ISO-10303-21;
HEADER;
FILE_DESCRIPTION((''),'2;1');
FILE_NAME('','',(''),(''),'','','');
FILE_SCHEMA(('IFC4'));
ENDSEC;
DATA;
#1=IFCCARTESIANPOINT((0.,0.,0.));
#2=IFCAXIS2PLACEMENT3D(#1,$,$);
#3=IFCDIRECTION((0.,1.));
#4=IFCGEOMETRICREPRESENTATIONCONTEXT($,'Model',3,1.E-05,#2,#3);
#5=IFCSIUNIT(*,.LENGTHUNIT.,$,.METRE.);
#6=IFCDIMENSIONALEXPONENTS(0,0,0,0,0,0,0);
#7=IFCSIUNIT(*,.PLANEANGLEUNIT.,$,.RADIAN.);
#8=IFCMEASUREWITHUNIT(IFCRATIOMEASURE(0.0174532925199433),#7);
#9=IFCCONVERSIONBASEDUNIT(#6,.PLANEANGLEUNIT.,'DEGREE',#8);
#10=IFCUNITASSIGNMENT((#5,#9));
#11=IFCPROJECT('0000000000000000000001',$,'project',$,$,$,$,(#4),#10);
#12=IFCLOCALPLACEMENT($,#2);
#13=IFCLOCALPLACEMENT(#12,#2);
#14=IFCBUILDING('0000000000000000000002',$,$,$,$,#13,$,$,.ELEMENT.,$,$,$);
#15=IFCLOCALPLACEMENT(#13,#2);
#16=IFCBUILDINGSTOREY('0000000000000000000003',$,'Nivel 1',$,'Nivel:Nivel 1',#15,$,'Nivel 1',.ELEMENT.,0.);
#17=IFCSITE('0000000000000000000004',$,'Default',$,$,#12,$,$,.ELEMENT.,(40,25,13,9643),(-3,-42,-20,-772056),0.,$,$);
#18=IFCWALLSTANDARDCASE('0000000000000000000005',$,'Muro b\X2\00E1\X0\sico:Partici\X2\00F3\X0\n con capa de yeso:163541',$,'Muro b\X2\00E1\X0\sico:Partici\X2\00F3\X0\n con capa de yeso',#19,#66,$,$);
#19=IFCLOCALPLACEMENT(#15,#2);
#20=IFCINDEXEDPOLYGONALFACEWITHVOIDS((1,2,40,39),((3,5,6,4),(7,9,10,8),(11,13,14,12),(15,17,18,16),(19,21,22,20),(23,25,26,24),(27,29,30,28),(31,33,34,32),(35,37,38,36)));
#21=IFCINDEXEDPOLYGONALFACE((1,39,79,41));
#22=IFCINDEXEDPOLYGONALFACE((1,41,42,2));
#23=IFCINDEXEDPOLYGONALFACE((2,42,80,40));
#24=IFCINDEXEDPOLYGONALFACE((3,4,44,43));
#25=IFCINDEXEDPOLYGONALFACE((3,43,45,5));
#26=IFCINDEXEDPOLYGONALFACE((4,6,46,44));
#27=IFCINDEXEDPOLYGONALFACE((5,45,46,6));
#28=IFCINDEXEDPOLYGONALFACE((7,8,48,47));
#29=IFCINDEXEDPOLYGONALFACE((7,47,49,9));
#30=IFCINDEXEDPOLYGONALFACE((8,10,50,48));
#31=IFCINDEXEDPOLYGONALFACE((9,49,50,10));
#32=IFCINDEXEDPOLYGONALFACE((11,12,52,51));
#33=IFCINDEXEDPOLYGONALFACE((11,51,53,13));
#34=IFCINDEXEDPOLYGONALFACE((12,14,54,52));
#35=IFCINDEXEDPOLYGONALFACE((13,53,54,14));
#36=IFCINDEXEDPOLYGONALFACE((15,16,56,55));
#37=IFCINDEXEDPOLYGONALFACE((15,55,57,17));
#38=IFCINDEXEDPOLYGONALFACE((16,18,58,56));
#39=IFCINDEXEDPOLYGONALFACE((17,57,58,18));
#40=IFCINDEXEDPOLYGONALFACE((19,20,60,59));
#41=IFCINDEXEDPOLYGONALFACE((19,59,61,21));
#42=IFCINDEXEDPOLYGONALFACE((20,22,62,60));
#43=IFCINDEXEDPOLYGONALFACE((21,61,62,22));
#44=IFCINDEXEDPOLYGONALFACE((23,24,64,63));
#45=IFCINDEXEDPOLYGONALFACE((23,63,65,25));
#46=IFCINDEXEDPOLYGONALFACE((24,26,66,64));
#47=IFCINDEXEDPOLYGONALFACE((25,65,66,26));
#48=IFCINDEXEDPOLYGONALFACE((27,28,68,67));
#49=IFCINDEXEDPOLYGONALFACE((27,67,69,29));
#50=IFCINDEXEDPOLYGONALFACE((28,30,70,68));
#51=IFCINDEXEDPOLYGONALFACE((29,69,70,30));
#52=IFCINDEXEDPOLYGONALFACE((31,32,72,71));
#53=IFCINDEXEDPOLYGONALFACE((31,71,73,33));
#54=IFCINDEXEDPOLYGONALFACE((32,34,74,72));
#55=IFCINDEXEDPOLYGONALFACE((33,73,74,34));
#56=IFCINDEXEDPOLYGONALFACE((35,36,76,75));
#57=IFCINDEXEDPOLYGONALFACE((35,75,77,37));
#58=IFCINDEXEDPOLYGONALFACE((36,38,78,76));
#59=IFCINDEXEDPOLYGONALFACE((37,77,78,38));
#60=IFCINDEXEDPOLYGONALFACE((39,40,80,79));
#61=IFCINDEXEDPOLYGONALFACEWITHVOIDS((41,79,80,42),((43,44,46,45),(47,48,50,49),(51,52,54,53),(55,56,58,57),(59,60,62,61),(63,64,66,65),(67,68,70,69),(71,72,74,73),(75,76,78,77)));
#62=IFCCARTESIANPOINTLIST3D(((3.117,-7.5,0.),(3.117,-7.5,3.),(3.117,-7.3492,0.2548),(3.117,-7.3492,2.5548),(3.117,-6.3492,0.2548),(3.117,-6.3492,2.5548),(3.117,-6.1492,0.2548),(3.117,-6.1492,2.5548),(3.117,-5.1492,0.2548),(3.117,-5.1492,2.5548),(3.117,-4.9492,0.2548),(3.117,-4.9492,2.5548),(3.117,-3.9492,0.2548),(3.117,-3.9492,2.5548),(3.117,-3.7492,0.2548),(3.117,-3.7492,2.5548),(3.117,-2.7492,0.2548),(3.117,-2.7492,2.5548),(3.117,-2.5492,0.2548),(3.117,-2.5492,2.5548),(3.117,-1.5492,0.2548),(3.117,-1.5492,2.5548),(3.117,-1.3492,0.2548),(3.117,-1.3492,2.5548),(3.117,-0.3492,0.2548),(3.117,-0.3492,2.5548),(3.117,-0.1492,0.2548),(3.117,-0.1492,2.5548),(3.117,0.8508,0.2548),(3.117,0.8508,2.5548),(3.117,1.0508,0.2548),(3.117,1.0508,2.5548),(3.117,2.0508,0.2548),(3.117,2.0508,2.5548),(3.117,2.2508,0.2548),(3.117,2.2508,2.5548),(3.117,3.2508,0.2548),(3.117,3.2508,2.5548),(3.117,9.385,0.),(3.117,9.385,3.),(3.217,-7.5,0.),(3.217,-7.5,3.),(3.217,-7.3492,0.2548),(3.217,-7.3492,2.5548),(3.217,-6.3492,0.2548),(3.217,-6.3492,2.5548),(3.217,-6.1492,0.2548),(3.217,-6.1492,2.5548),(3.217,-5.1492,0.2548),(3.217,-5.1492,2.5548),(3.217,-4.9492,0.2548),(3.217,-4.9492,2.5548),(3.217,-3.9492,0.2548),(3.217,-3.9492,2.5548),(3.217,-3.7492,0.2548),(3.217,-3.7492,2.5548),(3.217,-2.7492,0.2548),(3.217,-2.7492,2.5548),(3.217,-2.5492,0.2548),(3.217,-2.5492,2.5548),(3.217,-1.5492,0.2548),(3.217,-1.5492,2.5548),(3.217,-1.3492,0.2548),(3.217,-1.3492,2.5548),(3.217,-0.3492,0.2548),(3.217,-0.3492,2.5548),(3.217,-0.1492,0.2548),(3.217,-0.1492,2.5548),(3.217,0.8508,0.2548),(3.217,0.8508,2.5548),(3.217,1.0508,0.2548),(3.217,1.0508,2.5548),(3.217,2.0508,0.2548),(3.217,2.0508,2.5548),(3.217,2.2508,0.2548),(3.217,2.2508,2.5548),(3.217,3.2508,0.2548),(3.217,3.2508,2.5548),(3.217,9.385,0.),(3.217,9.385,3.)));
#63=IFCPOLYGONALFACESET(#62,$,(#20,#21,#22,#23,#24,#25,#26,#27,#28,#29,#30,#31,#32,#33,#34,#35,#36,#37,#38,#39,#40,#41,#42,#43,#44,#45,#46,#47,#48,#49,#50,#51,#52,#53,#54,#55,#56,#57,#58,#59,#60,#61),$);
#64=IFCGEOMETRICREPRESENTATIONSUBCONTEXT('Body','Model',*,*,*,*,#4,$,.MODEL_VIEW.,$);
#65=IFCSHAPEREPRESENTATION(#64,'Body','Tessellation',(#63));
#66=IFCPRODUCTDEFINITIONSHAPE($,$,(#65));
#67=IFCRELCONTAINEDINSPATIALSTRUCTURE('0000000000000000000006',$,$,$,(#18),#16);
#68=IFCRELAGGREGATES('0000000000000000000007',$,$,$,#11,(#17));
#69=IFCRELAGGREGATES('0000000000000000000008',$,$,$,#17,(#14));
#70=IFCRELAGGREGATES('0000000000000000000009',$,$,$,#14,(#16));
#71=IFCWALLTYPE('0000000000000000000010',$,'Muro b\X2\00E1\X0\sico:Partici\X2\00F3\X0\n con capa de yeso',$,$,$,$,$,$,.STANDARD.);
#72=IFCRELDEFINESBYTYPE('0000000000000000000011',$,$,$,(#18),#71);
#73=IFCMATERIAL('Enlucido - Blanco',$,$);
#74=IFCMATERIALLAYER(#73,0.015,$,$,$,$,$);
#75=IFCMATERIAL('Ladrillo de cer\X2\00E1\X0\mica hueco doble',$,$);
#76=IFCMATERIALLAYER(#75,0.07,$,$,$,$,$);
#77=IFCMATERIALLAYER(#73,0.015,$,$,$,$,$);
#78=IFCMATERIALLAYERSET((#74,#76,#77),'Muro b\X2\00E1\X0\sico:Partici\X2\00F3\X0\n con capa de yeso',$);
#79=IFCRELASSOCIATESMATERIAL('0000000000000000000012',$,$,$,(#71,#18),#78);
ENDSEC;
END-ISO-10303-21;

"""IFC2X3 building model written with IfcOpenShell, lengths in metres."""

from ifc_helpers import new_model, entity, si_unit, converted_unit, direction, frame, frame_2d, origin, place, context, subcontext, project, spatial, rectangle, extrude, material, layer, layer_set, layer_usage, type_object, element, save


model = new_model("IFC2X3")

# Units and contexts
model_context = context("Model", 3, precision=1e-05, world=origin(), true_north=direction((0.0, 1.0)))
body_context = subcontext(model_context, "Body", "Model", "MODEL_VIEW")
ifc_project = project(units=[si_unit("LENGTHUNIT", "METRE"), converted_unit("PLANEANGLEUNIT", "DEGREE", entity("IfcRatioMeasure", 0.0174532925199433), si_unit("PLANEANGLEUNIT", "RADIAN"), dimensions=[0, 0, 0, 0, 0, 0, 0])], contexts=[model_context])

# Site, building, storey
site_placement = place(None, origin())
site = spatial("IfcSite", under=ifc_project, at=site_placement, Name="Default", CompositionType="ELEMENT", RefLatitude=(40, 25, 13, 9643), RefLongitude=(-3, -42, -20, -772056), RefElevation=0.0)
building_placement = place(site_placement, origin())
building = spatial("IfcBuilding", under=site, at=building_placement, CompositionType="ELEMENT")
storey_placement = place(building_placement, origin())
storey = spatial("IfcBuildingStorey", under=building, at=storey_placement, Name="Nivel 1", ObjectType="Nivel:Nivel 1", LongName="Nivel 1", CompositionType="ELEMENT", Elevation=0.0)

# Shared definitions
ifc_material_1 = material(Name="Enlucido - Blanco")
ifc_layer_1 = layer(ifc_material_1, 0.015)
ifc_material_2 = material(Name="Ladrillo de cerámica hueco doble")
ifc_layer_2 = layer(ifc_material_2, 0.07)
ifc_layer_3 = layer(ifc_material_1, 0.015)
ifc_layer_set_1 = layer_set([ifc_layer_1, ifc_layer_2, ifc_layer_3], Name="Muro básico:Partición con capa de yeso")
wall_type = type_object("IfcWallType", Name="Muro básico:Partición con capa de yeso", PredefinedType="STANDARD", material=ifc_layer_set_1)

# Wall, openings
ifc_layer_usage_1 = layer_usage(ifc_layer_set_1, "AXIS2", "NEGATIVE", 0.05)
wall_1_placement = place(storey_placement, frame((3.167, 9.385, 0.0), z_axis=(0.0, 0.0, 1.0), x_axis=(0.0, -1.0, 0.0)))
wall_1 = element("IfcWallStandardCase", 1, at=wall_1_placement, inside=storey, type_object=wall_type, material=ifc_layer_usage_1, Name="Muro básico:Partición con capa de yeso:163541", ObjectType="Muro básico:Partición con capa de yeso", context=body_context, shape_type="SweptSolid", body=[
    extrude(rectangle(XDim=16.885, YDim=0.1, at=frame_2d((8.4425, 0.0), x_axis=(-1.0, 0.0))), origin(), (0.0, 0.0, 1.0), 3.0),
])
opening_1_placement = place(wall_1_placement, frame((6.1342, -0.05, 0.2548)))
element("IfcOpeningElement", 2, at=opening_1_placement, cuts=wall_1, ObjectType="Opening", context=body_context, shape_type="SweptSolid", body=[
    extrude(rectangle(XDim=2.3, YDim=1.0, at=frame_2d((1.15, 0.5), x_axis=(1.0, 0.0))), frame((0.0, 0.0, 0.0), z_axis=(0.0, 1.0, 0.0), x_axis=(0.0, 0.0, 1.0)), (0.0, 0.0, 1.0), 0.1),
])
opening_2_placement = place(wall_1_placement, frame((7.3342, -0.05, 0.2548)))
element("IfcOpeningElement", 3, at=opening_2_placement, cuts=wall_1, ObjectType="Opening", context=body_context, shape_type="SweptSolid", body=[
    extrude(rectangle(XDim=2.3, YDim=1.0, at=frame_2d((1.15, 0.5), x_axis=(1.0, 0.0))), frame((0.0, 0.0, 0.0), z_axis=(0.0, 1.0, 0.0), x_axis=(0.0, 0.0, 1.0)), (0.0, 0.0, 1.0), 0.1),
])
opening_3_placement = place(wall_1_placement, frame((8.5342, -0.05, 0.2548)))
element("IfcOpeningElement", 4, at=opening_3_placement, cuts=wall_1, ObjectType="Opening", context=body_context, shape_type="SweptSolid", body=[
    extrude(rectangle(XDim=2.3, YDim=1.0, at=frame_2d((1.15, 0.5), x_axis=(1.0, 0.0))), frame((0.0, 0.0, 0.0), z_axis=(0.0, 1.0, 0.0), x_axis=(0.0, 0.0, 1.0)), (0.0, 0.0, 1.0), 0.1),
])
opening_4_placement = place(wall_1_placement, frame((9.7342, -0.05, 0.2548)))
element("IfcOpeningElement", 5, at=opening_4_placement, cuts=wall_1, ObjectType="Opening", context=body_context, shape_type="SweptSolid", body=[
    extrude(rectangle(XDim=2.3, YDim=1.0, at=frame_2d((1.15, 0.5), x_axis=(1.0, 0.0))), frame((0.0, 0.0, 0.0), z_axis=(0.0, 1.0, 0.0), x_axis=(0.0, 0.0, 1.0)), (0.0, 0.0, 1.0), 0.1),
])
opening_5_placement = place(wall_1_placement, frame((15.7342, -0.05, 0.2548)))
element("IfcOpeningElement", 6, at=opening_5_placement, cuts=wall_1, ObjectType="Opening", context=body_context, shape_type="SweptSolid", body=[
    extrude(rectangle(XDim=2.3, YDim=1.0, at=frame_2d((1.15, 0.5), x_axis=(1.0, 0.0))), frame((0.0, 0.0, 0.0), z_axis=(0.0, 1.0, 0.0), x_axis=(0.0, 0.0, 1.0)), (0.0, 0.0, 1.0), 0.1),
])
opening_6_placement = place(wall_1_placement, frame((14.5342, -0.05, 0.2548)))
element("IfcOpeningElement", 7, at=opening_6_placement, cuts=wall_1, ObjectType="Opening", context=body_context, shape_type="SweptSolid", body=[
    extrude(rectangle(XDim=2.3, YDim=1.0, at=frame_2d((1.15, 0.5), x_axis=(1.0, 0.0))), frame((0.0, 0.0, 0.0), z_axis=(0.0, 1.0, 0.0), x_axis=(0.0, 0.0, 1.0)), (0.0, 0.0, 1.0), 0.1),
])
opening_7_placement = place(wall_1_placement, frame((13.3342, -0.05, 0.2548)))
element("IfcOpeningElement", 8, at=opening_7_placement, cuts=wall_1, ObjectType="Opening", context=body_context, shape_type="SweptSolid", body=[
    extrude(rectangle(XDim=2.3, YDim=1.0, at=frame_2d((1.15, 0.5), x_axis=(1.0, 0.0))), frame((0.0, 0.0, 0.0), z_axis=(0.0, 1.0, 0.0), x_axis=(0.0, 0.0, 1.0)), (0.0, 0.0, 1.0), 0.1),
])
opening_8_placement = place(wall_1_placement, frame((12.1342, -0.05, 0.2548)))
element("IfcOpeningElement", 9, at=opening_8_placement, cuts=wall_1, ObjectType="Opening", context=body_context, shape_type="SweptSolid", body=[
    extrude(rectangle(XDim=2.3, YDim=1.0, at=frame_2d((1.15, 0.5), x_axis=(1.0, 0.0))), frame((0.0, 0.0, 0.0), z_axis=(0.0, 1.0, 0.0), x_axis=(0.0, 0.0, 1.0)), (0.0, 0.0, 1.0), 0.1),
])
opening_9_placement = place(wall_1_placement, frame((10.9342, -0.05, 0.2548)))
element("IfcOpeningElement", 10, at=opening_9_placement, cuts=wall_1, ObjectType="Opening", context=body_context, shape_type="SweptSolid", body=[
    extrude(rectangle(XDim=2.3, YDim=1.0, at=frame_2d((1.15, 0.5), x_axis=(1.0, 0.0))), frame((0.0, 0.0, 0.0), z_axis=(0.0, 1.0, 0.0), x_axis=(0.0, 0.0, 1.0)), (0.0, 0.0, 1.0), 0.1),
])

save(model, "model.ifc")
